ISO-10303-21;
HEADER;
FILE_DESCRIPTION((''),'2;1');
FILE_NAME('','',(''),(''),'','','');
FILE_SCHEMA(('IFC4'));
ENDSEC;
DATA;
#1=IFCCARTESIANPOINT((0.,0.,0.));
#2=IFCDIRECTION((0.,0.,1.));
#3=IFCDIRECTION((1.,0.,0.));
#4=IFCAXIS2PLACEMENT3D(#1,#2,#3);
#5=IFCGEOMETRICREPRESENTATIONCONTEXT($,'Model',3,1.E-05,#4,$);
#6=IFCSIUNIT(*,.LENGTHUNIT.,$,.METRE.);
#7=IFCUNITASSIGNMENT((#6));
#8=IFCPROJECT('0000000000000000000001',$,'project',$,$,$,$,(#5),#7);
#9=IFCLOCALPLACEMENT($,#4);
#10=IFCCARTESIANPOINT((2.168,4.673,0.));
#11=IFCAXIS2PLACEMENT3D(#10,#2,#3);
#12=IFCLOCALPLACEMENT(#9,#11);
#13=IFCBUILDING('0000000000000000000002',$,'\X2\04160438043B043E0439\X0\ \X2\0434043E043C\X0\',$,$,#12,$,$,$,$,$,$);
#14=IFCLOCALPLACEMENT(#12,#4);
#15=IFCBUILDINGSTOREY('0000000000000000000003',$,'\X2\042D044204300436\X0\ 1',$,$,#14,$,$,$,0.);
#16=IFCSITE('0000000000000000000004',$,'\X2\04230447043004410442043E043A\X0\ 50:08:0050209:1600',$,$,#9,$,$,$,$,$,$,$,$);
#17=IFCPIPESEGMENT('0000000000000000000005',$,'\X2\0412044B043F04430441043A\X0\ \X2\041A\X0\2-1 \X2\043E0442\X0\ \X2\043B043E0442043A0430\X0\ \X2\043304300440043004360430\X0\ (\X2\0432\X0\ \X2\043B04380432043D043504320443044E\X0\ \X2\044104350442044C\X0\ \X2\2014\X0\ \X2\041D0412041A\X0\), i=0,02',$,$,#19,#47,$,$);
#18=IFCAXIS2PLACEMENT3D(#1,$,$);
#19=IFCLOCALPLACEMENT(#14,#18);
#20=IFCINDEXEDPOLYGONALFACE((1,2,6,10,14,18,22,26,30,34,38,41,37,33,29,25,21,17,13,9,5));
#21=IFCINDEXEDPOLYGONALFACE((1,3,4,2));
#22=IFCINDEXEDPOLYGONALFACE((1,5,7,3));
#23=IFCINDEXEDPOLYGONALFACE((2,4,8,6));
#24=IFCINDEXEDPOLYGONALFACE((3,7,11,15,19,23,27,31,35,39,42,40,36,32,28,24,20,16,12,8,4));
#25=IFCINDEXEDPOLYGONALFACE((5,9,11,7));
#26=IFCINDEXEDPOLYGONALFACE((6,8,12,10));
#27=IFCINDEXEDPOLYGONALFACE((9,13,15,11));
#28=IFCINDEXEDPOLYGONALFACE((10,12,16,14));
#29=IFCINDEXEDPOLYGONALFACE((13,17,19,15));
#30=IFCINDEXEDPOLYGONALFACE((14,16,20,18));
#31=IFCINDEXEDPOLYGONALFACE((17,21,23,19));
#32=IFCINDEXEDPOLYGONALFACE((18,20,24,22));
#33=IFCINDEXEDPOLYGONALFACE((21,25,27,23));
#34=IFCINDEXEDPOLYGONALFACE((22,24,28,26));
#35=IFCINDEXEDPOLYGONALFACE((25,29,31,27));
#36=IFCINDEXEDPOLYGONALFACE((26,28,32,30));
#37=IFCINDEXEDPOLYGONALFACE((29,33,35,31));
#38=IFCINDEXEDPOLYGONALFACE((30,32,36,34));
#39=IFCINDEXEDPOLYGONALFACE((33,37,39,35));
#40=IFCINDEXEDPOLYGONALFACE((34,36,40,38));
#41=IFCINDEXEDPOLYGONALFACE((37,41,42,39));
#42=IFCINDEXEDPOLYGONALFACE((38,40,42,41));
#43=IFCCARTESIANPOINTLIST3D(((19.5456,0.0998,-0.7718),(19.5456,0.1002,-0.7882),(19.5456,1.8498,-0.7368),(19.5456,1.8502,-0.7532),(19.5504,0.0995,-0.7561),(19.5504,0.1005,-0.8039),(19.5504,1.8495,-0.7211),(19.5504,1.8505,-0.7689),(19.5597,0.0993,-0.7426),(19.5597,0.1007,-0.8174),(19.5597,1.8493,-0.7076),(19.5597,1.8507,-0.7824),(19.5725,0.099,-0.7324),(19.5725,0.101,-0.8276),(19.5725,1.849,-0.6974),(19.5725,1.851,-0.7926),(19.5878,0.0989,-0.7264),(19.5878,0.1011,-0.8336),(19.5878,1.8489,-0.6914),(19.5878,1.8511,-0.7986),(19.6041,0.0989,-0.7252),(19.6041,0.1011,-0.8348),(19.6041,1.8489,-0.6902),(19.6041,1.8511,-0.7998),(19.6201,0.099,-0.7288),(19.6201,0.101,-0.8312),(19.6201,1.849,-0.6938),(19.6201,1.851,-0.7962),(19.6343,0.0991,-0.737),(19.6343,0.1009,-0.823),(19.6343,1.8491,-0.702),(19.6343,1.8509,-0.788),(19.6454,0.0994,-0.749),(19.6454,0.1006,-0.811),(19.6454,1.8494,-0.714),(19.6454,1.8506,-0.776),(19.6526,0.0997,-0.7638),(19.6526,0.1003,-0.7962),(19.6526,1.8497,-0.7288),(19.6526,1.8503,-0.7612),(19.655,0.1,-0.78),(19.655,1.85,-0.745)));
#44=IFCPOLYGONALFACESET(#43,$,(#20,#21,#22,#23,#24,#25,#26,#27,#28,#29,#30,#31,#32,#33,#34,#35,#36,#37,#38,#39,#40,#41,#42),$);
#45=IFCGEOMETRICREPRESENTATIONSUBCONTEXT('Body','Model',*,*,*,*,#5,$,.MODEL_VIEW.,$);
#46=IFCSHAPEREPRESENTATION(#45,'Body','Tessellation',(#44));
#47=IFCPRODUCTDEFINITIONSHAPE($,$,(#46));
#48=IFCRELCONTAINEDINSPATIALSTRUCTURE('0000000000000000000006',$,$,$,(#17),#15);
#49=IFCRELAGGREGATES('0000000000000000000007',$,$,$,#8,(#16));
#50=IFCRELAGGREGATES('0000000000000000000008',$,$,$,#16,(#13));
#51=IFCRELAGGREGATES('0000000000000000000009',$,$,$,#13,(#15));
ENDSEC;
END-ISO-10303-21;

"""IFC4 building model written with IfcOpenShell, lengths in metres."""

from ifc_helpers import new_model, si_unit, frame, origin_with_axes, origin_2d, place, context, subcontext, project, spatial, circle, extrude, element, save


model = new_model("IFC4")

# Units and contexts
model_context = context("Model", 3, precision=1e-05, world=origin_with_axes())
body_context = subcontext(model_context, "Body", "Model", "MODEL_VIEW")
ifc_project = project(units=[si_unit("LENGTHUNIT", "METRE")], contexts=[model_context])

# Site, building, storey
site_placement = place(None, origin_with_axes())
site = spatial("IfcSite", under=ifc_project, at=site_placement, Name="Участок 50:08:0050209:1600")
building_placement = place(site_placement, frame((2.168, 4.673, 0.0), z_axis=(0.0, 0.0, 1.0), x_axis=(1.0, 0.0, 0.0)))
building = spatial("IfcBuilding", under=site, at=building_placement, Name="Жилой дом")
storey_placement = place(building_placement, origin_with_axes())
storey = spatial("IfcBuildingStorey", under=building, at=storey_placement, Name="Этаж 1", Elevation=0.0)

# Pipe segment
pipe_segment_1_placement = place(storey_placement, origin_with_axes())
element("IfcPipeSegment", 1, at=pipe_segment_1_placement, inside=storey, Name="Выпуск К2-1 от лотка гаража (в ливневую сеть — НВК), i=0,02", context=body_context, shape_type="SweptSolid", body=[
    extrude(circle(Radius=0.055, at=origin_2d()), frame((19.6, 1.85, -0.745), z_axis=(0.0, -0.9998, -0.019996), x_axis=(1.0, 0.0, 0.0)), (0.0, 0.0, 1.0), 1.7503),
])

save(model, "model.ifc")
